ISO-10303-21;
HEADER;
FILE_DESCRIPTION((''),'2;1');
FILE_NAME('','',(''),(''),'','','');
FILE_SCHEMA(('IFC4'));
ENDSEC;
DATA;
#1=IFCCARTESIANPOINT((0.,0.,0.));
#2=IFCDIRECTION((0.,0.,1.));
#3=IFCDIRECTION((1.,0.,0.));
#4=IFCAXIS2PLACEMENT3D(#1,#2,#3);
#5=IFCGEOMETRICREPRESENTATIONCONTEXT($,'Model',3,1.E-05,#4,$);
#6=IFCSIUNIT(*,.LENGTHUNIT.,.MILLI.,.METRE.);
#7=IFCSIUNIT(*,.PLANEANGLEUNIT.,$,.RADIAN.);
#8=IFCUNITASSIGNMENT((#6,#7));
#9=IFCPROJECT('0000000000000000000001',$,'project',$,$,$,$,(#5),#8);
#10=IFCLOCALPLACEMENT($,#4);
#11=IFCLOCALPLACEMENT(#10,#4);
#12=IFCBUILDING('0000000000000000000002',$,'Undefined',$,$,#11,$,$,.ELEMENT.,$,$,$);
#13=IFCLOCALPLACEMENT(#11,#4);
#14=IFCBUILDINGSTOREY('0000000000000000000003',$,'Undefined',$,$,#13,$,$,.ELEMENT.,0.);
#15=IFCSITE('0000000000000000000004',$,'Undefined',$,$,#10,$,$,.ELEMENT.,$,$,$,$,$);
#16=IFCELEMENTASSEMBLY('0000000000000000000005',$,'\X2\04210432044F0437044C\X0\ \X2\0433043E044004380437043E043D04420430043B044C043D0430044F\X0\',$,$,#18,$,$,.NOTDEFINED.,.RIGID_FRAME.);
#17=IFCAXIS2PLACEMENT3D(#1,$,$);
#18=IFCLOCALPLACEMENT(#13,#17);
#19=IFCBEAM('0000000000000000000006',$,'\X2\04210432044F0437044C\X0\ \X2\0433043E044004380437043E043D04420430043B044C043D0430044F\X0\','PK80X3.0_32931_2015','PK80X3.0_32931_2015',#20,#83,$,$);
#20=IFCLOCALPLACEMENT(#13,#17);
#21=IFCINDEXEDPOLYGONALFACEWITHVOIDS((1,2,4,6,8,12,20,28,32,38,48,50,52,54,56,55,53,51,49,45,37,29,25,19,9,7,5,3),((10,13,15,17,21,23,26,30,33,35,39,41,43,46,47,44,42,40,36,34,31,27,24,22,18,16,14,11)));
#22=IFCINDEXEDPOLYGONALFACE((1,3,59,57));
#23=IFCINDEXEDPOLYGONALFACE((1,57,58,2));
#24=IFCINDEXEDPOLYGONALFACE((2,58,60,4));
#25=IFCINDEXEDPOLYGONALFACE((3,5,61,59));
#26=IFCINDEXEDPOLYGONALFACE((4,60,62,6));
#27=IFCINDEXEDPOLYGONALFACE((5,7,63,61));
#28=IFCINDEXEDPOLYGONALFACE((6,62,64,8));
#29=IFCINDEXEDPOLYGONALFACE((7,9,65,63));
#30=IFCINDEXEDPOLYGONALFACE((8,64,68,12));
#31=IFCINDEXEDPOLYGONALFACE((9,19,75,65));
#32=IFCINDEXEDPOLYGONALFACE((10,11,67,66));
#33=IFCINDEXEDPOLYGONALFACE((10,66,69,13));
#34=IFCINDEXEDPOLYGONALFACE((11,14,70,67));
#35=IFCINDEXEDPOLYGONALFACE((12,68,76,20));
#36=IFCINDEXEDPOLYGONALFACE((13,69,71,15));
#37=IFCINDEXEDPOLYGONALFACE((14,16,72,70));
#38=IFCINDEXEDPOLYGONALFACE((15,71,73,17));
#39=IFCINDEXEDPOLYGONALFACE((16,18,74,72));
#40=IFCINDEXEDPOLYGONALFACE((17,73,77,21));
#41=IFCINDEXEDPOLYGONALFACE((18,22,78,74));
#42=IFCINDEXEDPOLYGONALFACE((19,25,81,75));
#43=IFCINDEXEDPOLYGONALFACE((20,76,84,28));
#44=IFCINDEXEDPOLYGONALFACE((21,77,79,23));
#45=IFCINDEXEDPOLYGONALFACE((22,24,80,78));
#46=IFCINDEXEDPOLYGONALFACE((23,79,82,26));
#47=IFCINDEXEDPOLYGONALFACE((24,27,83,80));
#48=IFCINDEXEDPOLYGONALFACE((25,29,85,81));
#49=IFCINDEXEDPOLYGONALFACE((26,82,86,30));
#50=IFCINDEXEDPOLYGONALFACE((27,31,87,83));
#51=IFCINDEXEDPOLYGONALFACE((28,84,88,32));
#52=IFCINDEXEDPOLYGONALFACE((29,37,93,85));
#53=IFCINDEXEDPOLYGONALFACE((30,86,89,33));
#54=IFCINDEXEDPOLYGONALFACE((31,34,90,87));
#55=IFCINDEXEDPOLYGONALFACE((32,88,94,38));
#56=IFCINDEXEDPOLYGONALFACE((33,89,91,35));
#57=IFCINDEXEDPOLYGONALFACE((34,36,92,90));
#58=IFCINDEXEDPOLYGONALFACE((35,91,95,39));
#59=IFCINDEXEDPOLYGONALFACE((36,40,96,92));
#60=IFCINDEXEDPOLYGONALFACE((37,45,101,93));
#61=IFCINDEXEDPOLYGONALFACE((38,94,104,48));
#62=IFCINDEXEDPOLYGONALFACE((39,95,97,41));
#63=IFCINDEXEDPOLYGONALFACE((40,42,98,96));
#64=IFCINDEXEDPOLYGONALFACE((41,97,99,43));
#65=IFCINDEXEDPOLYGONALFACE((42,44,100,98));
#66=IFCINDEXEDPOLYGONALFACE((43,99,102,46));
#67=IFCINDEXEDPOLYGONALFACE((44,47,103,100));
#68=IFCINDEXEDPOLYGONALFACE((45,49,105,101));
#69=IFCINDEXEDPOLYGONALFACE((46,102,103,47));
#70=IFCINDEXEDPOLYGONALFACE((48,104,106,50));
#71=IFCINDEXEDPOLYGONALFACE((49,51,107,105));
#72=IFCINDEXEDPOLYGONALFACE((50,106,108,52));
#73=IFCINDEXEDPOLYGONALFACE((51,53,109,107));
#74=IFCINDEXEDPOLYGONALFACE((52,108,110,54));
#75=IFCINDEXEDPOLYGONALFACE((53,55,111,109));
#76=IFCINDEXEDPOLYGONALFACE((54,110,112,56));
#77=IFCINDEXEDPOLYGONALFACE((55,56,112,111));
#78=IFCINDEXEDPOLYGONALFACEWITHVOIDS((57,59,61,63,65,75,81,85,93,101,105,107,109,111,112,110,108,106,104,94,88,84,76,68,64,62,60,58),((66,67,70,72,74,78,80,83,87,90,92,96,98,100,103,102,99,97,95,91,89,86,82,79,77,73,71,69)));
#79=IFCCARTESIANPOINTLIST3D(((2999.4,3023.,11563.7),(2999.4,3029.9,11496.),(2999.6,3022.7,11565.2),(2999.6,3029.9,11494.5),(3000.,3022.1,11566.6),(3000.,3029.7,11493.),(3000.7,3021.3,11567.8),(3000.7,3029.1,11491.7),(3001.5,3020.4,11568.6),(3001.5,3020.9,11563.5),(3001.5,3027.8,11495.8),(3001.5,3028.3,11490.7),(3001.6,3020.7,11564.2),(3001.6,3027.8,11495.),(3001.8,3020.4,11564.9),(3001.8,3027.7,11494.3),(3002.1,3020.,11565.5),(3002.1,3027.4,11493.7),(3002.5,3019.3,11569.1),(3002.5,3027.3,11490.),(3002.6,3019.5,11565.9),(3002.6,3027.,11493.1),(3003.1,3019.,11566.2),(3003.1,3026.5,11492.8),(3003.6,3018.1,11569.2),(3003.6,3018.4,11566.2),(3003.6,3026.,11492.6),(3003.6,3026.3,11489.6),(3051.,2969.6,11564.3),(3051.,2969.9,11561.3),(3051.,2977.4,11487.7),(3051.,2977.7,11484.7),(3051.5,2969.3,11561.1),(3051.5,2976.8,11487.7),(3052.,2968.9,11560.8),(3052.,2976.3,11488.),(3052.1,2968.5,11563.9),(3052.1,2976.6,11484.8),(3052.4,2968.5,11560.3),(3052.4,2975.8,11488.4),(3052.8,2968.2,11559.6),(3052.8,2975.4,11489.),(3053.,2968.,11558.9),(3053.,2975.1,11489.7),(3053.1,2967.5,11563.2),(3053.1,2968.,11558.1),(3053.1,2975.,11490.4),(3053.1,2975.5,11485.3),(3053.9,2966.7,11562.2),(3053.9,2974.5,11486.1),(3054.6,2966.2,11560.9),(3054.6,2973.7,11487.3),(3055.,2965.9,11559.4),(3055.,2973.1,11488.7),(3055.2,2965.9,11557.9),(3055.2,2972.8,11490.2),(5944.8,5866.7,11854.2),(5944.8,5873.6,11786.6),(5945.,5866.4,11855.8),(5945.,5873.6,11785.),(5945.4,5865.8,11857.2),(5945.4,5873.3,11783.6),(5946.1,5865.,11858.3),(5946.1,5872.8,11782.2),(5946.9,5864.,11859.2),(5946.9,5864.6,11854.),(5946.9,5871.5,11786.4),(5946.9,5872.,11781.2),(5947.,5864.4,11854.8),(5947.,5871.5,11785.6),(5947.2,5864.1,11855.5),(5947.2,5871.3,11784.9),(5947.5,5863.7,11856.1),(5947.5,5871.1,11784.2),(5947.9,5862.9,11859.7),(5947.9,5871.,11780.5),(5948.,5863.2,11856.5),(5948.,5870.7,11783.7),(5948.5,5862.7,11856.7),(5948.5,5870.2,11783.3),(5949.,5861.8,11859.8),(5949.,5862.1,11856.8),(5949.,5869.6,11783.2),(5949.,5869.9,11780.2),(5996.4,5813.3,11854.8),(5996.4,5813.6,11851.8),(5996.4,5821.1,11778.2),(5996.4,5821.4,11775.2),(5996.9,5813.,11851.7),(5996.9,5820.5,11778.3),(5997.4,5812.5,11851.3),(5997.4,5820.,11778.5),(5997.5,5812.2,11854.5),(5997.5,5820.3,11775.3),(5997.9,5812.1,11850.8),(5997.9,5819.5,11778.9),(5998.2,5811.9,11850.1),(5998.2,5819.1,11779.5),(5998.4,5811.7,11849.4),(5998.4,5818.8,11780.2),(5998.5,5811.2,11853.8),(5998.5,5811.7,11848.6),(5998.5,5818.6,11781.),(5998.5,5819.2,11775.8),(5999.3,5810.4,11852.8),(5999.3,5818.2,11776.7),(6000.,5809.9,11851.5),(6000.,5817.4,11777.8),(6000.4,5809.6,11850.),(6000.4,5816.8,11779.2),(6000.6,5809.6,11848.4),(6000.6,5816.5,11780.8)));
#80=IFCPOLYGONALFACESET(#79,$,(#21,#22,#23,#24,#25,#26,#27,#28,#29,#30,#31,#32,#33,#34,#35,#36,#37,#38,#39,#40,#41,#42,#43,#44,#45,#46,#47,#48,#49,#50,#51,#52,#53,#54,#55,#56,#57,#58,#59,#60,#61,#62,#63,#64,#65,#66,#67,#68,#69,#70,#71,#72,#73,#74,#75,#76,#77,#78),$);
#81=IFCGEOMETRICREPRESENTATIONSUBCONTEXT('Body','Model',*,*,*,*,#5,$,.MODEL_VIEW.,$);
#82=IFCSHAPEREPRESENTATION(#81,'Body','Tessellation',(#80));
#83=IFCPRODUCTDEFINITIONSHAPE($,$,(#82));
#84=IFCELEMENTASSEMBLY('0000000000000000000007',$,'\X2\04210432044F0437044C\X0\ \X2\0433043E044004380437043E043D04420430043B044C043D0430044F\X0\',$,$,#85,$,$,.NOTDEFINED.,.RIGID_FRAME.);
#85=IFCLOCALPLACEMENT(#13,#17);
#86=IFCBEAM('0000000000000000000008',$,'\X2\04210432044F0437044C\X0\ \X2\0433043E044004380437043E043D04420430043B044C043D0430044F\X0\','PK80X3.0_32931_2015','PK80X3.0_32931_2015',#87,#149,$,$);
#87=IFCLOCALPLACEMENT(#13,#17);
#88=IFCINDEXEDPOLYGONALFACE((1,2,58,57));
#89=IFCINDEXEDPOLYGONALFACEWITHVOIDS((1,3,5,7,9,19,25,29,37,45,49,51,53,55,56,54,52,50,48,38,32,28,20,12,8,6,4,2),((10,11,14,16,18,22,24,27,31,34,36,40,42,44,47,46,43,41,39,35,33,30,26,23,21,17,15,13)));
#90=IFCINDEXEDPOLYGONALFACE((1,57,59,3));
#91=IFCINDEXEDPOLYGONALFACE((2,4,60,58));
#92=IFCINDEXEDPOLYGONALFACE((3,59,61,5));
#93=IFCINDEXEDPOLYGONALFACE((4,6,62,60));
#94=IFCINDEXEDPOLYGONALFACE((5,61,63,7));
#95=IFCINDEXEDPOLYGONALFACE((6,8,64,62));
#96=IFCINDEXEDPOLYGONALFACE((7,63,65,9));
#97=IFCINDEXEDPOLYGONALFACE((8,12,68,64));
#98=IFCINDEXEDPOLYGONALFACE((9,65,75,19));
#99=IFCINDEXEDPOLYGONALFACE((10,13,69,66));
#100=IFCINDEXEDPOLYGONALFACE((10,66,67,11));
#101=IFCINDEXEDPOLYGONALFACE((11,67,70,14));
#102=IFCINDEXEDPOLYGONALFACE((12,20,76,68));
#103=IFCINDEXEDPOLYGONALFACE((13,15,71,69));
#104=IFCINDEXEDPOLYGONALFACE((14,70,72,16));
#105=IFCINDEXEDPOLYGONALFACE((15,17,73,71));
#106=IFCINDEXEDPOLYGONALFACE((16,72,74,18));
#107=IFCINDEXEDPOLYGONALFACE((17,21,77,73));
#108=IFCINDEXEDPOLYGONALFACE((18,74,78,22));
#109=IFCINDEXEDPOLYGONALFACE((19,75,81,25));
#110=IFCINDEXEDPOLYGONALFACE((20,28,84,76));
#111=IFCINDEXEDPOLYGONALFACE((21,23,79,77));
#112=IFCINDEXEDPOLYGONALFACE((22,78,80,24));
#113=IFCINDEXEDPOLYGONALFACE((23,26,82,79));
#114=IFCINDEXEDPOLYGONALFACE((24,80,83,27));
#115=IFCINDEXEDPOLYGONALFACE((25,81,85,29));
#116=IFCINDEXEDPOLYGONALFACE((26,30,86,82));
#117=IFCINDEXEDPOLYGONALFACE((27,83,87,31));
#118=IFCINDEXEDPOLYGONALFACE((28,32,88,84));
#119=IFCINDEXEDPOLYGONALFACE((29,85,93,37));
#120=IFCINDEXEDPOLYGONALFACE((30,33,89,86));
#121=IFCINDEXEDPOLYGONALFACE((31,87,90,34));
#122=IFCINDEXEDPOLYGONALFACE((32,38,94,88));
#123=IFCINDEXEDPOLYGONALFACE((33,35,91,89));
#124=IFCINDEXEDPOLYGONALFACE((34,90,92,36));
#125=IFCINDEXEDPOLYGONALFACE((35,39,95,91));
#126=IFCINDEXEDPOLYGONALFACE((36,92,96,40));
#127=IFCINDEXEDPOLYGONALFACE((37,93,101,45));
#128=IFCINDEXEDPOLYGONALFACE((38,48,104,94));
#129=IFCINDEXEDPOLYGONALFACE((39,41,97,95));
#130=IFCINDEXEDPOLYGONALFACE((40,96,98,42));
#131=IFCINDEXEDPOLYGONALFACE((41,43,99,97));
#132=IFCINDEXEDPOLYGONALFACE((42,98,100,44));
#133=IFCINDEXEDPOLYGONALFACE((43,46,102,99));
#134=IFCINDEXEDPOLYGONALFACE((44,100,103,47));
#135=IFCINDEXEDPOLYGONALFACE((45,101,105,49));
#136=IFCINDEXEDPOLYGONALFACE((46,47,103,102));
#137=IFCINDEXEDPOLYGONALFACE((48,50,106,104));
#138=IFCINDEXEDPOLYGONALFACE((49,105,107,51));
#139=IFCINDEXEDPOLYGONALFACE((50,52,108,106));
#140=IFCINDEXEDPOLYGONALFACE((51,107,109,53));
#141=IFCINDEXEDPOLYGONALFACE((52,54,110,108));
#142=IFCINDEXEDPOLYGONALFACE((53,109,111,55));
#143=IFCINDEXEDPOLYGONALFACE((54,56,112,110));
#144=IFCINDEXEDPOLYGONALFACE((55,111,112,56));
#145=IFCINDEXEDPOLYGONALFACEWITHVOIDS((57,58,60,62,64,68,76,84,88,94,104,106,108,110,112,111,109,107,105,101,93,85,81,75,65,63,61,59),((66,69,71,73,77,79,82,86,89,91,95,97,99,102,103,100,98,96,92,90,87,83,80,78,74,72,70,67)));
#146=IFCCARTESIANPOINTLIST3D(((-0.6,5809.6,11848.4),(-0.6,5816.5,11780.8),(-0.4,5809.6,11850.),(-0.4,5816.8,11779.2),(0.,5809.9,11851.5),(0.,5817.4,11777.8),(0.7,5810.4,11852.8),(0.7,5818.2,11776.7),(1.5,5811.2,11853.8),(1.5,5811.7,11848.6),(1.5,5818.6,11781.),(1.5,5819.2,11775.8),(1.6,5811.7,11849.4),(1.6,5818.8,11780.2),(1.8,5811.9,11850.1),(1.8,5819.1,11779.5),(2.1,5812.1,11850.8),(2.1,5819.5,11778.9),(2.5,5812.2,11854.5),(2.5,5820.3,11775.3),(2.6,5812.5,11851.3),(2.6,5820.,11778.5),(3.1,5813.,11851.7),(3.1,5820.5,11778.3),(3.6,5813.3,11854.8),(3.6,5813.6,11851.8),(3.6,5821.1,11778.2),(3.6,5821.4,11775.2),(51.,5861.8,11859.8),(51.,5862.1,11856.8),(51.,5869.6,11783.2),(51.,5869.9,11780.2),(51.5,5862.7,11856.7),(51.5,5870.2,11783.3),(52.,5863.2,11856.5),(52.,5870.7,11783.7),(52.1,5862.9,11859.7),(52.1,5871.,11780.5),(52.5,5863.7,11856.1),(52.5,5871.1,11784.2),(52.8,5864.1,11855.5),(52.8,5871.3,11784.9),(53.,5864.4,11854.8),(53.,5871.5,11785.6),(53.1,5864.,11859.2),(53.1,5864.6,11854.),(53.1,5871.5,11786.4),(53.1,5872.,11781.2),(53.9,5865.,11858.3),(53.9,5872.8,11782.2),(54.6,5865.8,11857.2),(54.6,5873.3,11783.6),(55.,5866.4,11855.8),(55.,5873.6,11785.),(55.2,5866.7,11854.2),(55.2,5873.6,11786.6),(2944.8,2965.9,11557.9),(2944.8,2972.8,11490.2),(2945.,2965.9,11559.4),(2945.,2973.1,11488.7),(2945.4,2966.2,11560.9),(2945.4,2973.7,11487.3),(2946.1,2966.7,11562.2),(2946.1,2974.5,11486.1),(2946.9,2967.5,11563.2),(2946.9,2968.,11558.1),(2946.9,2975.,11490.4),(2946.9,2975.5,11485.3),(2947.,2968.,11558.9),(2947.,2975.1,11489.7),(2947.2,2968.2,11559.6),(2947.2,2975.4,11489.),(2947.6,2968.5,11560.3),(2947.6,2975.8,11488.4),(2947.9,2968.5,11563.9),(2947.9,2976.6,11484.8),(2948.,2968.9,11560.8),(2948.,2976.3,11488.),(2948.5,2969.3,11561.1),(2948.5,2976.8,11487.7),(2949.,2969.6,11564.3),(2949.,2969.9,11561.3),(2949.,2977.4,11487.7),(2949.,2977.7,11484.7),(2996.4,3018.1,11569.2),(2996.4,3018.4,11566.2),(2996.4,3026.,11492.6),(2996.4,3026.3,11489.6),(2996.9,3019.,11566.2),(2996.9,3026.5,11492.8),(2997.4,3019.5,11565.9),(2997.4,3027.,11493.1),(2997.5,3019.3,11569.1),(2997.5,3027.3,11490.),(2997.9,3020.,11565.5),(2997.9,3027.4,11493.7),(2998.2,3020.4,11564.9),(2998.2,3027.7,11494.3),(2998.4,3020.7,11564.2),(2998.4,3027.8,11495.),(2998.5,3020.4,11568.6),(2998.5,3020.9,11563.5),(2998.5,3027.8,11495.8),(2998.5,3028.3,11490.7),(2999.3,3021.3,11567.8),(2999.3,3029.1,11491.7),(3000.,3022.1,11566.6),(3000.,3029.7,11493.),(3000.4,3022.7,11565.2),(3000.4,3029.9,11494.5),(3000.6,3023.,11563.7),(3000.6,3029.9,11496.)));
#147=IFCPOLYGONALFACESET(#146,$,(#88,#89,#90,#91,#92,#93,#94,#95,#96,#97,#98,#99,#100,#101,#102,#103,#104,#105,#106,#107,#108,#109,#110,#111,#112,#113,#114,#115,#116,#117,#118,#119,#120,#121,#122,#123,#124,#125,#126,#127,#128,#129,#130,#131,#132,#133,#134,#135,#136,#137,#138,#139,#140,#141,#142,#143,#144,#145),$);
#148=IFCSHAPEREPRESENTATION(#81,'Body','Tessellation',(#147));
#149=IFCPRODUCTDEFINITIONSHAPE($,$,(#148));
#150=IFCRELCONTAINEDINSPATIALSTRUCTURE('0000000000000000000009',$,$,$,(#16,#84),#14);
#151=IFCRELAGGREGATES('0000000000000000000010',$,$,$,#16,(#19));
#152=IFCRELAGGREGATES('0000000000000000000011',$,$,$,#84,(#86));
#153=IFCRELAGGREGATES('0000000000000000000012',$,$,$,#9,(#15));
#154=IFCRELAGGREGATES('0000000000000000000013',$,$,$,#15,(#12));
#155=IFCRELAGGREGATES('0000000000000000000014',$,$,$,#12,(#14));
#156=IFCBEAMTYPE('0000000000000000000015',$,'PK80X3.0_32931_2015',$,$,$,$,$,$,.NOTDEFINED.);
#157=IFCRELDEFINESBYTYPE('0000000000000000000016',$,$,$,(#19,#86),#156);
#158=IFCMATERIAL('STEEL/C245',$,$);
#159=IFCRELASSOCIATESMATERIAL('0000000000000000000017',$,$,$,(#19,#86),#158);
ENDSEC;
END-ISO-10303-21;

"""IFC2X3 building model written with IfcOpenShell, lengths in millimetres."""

from ifc_helpers import new_model, si_unit, frame, origin_with_axes, origin_2d_with_axis, place, context, subcontext, project, spatial, hollow_rectangle, extrude, material, type_object, element, aggregate, save


model = new_model("IFC2X3")

# Units and contexts
model_context = context("Model", 3, precision=1e-05, world=origin_with_axes())
body_context = subcontext(model_context, "Body", "Model", "MODEL_VIEW")
ifc_project = project(units=[si_unit("LENGTHUNIT", "METRE", prefix="MILLI"), si_unit("PLANEANGLEUNIT", "RADIAN")], contexts=[model_context])

# Site, building, storey
site_placement = place(None, origin_with_axes())
site = spatial("IfcSite", under=ifc_project, at=site_placement, Name="Undefined", CompositionType="ELEMENT")
building_placement = place(site_placement, origin_with_axes())
building = spatial("IfcBuilding", under=site, at=building_placement, Name="Undefined", CompositionType="ELEMENT")
storey_placement = place(building_placement, origin_with_axes())
storey = spatial("IfcBuildingStorey", under=building, at=storey_placement, Name="Undefined", CompositionType="ELEMENT", Elevation=0.0)

# Element assemblies, beams
ifc_material_1 = material(Name="STEEL/C245")
beam_type_1 = type_object("IfcBeamType", Name="PK80X3.0_32931_2015", PredefinedType="NOTDEFINED")
assembly_1_placement = place(storey_placement, origin_with_axes())
assembly_1 = element("IfcElementAssembly", 1, at=assembly_1_placement, inside=storey, Name="Связь горизонтальная", AssemblyPlace="NOTDEFINED", PredefinedType="RIGID_FRAME")
beam_1_placement = place(assembly_1_placement, frame((5972.7, 5841.6, 11817.5), z_axis=(0.0, -0.101645, 0.994821), x_axis=(-0.717617, -0.69283, -0.070789)))
beam_1 = element("IfcBeam", 2, at=beam_1_placement, type_object=beam_type_1, material=ifc_material_1, Name="Связь горизонтальная", Description="PK80X3.0_32931_2015", ObjectType="PK80X3.0_32931_2015", context=body_context, shape_type="SweptSolid", body=[
    extrude(hollow_rectangle(XDim=80.0, YDim=80.0, WallThickness=3.0, InnerFilletRadius=3.0, OuterFilletRadius=6.0, at=origin_2d_with_axis()), frame((4104.4, 0.0, 0.0), z_axis=(-1.0, 0.0, 0.0), x_axis=(0.0, -1.0, 0.0)), (0.0, 0.0, 1.0), 4104.4),
])
aggregate(assembly_1, [beam_1])
assembly_2_placement = place(storey_placement, origin_with_axes())
assembly_2 = element("IfcElementAssembly", 3, at=assembly_2_placement, inside=storey, Name="Связь горизонтальная", AssemblyPlace="NOTDEFINED", PredefinedType="RIGID_FRAME")
beam_2_placement = place(assembly_2_placement, frame((27.3, 5841.6, 11817.5), z_axis=(0.0, -0.101645, 0.994821), x_axis=(0.717617, -0.69283, -0.070789)))
beam_2 = element("IfcBeam", 4, at=beam_2_placement, type_object=beam_type_1, material=ifc_material_1, Name="Связь горизонтальная", Description="PK80X3.0_32931_2015", ObjectType="PK80X3.0_32931_2015", context=body_context, shape_type="SweptSolid", body=[
    extrude(hollow_rectangle(XDim=80.0, YDim=80.0, WallThickness=3.0, InnerFilletRadius=3.0, OuterFilletRadius=6.0, at=origin_2d_with_axis()), frame((4104.4, 0.0, 0.0), z_axis=(-1.0, 0.0, 0.0), x_axis=(0.0, -1.0, 0.0)), (0.0, 0.0, 1.0), 4104.4),
])
aggregate(assembly_2, [beam_2])

save(model, "model.ifc")
